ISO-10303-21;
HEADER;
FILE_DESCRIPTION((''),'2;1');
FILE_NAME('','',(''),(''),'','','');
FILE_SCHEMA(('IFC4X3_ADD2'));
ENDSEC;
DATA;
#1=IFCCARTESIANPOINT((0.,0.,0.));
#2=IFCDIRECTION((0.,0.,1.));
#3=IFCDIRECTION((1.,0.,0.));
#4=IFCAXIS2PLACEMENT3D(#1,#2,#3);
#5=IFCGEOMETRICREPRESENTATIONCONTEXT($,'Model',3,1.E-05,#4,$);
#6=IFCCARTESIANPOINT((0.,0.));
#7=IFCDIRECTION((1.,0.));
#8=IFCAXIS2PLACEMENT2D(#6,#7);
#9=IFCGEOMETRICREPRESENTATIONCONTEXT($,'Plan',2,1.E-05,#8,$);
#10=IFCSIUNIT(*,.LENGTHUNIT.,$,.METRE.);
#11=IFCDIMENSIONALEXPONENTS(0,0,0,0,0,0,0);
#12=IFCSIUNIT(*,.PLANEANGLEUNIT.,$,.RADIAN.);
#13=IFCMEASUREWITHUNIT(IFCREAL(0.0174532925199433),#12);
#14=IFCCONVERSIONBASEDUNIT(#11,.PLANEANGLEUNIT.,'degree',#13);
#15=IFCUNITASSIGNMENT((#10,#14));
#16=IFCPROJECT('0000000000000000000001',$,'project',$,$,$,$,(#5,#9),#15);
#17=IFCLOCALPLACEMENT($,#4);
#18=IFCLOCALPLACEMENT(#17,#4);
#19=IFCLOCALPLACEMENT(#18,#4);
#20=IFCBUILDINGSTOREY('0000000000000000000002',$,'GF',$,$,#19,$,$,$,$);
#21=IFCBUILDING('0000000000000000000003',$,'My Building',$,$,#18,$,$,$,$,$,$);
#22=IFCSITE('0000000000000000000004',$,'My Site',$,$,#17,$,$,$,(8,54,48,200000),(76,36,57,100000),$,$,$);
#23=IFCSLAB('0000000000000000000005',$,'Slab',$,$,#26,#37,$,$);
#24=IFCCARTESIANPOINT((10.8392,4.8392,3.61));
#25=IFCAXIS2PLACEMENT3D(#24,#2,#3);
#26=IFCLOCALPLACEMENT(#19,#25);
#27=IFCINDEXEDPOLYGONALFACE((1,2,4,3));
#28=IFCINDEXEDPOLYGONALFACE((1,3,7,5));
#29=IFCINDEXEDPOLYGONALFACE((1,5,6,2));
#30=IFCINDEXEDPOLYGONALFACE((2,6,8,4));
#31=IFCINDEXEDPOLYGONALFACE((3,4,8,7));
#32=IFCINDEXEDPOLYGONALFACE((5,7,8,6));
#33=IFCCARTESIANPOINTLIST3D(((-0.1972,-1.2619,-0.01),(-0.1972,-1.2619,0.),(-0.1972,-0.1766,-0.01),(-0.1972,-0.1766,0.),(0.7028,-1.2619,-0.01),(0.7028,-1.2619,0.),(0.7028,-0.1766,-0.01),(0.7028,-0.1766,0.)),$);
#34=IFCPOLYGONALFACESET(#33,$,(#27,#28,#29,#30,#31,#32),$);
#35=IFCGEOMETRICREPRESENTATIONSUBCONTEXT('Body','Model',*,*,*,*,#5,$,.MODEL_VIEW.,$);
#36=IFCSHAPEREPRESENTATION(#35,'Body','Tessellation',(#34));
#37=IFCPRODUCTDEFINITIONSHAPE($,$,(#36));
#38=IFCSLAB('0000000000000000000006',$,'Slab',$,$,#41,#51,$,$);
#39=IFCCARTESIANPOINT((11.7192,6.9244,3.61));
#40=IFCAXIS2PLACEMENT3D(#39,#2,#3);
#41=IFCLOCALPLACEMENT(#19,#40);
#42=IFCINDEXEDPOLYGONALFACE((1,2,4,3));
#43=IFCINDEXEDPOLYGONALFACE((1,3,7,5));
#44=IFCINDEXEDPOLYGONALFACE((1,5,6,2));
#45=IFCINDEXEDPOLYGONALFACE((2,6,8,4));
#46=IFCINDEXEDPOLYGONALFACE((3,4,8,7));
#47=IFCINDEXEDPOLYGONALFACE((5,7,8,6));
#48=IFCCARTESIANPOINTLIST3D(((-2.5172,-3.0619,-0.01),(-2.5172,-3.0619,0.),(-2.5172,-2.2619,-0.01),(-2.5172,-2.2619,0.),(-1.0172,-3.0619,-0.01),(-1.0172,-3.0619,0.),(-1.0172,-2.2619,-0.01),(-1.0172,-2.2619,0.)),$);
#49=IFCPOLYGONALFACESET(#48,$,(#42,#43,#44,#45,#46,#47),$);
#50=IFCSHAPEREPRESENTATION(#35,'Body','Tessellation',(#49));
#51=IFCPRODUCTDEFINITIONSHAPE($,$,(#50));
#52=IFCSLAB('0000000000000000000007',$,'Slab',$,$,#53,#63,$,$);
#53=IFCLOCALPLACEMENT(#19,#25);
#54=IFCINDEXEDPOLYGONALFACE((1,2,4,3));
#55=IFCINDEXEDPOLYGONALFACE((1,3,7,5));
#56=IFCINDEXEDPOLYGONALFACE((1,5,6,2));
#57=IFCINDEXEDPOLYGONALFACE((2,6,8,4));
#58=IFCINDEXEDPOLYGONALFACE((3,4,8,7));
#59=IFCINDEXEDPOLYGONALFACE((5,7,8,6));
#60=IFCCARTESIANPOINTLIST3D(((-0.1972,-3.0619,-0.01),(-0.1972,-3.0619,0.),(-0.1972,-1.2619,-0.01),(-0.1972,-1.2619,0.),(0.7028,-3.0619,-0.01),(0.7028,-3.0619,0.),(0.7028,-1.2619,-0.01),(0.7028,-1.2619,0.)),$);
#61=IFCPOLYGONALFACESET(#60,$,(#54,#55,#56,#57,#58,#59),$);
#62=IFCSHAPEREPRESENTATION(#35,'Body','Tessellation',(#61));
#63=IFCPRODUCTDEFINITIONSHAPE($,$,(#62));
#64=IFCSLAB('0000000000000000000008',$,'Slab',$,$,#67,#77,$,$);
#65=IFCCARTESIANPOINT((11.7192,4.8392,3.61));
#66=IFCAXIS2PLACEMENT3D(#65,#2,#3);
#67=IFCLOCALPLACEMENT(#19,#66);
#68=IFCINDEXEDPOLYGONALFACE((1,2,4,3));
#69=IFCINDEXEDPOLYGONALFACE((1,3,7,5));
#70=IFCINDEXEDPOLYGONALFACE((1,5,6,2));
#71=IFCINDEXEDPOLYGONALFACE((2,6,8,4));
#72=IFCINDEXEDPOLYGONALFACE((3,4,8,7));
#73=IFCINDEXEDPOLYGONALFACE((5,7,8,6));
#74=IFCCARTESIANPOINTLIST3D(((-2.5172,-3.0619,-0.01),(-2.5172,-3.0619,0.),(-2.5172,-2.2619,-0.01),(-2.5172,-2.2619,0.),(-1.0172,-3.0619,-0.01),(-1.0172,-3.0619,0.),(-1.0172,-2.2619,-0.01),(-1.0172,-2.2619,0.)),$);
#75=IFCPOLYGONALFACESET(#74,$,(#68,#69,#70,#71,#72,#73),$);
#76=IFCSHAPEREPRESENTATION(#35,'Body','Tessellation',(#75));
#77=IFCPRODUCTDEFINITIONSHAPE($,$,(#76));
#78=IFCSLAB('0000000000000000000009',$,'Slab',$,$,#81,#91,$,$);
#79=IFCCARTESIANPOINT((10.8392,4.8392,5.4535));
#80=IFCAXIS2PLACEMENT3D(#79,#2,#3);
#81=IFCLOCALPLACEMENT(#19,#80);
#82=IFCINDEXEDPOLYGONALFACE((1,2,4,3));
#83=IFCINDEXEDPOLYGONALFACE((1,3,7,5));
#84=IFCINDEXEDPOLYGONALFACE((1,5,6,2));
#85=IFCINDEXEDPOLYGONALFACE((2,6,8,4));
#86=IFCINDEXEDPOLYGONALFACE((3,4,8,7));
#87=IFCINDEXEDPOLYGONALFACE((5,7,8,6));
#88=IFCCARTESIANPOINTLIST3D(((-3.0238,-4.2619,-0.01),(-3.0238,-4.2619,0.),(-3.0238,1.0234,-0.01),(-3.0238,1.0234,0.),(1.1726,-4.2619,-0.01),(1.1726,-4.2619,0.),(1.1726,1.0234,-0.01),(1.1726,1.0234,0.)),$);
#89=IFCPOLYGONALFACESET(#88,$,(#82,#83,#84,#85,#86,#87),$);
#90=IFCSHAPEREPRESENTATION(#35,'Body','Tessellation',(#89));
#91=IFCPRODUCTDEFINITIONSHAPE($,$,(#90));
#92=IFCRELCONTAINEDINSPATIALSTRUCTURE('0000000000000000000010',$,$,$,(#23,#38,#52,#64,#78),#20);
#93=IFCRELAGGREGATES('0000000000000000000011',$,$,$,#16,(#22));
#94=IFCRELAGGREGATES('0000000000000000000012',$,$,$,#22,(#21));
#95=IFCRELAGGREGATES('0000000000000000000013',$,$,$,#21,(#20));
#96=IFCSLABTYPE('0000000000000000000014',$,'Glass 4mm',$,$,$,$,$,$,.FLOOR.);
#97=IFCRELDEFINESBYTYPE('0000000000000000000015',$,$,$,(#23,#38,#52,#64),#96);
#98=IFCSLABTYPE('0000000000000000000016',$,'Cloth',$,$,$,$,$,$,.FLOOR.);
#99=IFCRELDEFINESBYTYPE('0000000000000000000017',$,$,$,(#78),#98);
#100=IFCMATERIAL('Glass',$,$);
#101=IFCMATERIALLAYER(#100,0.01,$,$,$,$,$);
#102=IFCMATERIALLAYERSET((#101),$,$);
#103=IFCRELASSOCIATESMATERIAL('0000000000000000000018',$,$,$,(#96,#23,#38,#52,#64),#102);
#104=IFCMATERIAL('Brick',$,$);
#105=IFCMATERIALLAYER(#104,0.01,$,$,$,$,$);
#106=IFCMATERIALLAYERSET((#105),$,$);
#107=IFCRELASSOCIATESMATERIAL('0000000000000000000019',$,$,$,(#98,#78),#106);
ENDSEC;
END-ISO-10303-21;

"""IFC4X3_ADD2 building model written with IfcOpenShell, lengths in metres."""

from ifc_helpers import new_model, entity, si_unit, converted_unit, frame, origin_with_axes, origin_2d_with_axis, place, context, subcontext, project, spatial, indexed_curve, outline, extrude, material, layer, layer_set, layer_usage, type_object, element, save


model = new_model("IFC4X3_ADD2")

# Units and contexts
model_context = context("Model", 3, precision=1e-05, world=origin_with_axes())
plan_context = context("Plan", 2, precision=1e-05, world=origin_2d_with_axis())
body_context = subcontext(model_context, "Body", "Model", "MODEL_VIEW")
ifc_project = project(units=[si_unit("LENGTHUNIT", "METRE"), converted_unit("PLANEANGLEUNIT", "degree", entity("IfcReal", 0.0174532925199433), si_unit("PLANEANGLEUNIT", "RADIAN"), dimensions=[0, 0, 0, 0, 0, 0, 0])], contexts=[model_context, plan_context])

# Site, building, storey
site_placement = place(None, origin_with_axes())
site = spatial("IfcSite", under=ifc_project, at=site_placement, Name="My Site", RefLatitude=(8, 54, 48, 200000), RefLongitude=(76, 36, 57, 100000))
building_placement = place(site_placement, origin_with_axes())
building = spatial("IfcBuilding", under=site, at=building_placement, Name="My Building")
storey_placement = place(building_placement, origin_with_axes())
storey = spatial("IfcBuildingStorey", under=building, at=storey_placement, Name="GF")

# Slabs
ifc_material_1 = material(Name="Glass")
ifc_layer_1 = layer(ifc_material_1, 0.01)
ifc_layer_set_1 = layer_set([ifc_layer_1])
ifc_layer_usage_1 = layer_usage(ifc_layer_set_1, "AXIS3", "POSITIVE", -0.01)
slab_type_1 = type_object("IfcSlabType", Name="Glass 4mm", PredefinedType="FLOOR", material=ifc_layer_set_1)
slab_1_placement = place(storey_placement, frame((10.8392, 4.8392, 3.61), z_axis=(0.0, 0.0, 1.0), x_axis=(1.0, 0.0, 0.0)))
element("IfcSlab", 1, at=slab_1_placement, inside=storey, type_object=slab_type_1, material=ifc_layer_usage_1, Name="Slab", context=body_context, shape_type="SweptSolid", body=[
    extrude(outline(indexed_curve([(-0.1972, -0.1766), (0.7028, -0.1766), (0.7028, -1.2619), (-0.1972, -1.2619), (-0.1972, -0.1766)])), frame((0.0, 0.0, -0.01), z_axis=(0.0, 0.0, 1.0), x_axis=(1.0, 0.0, 0.0)), (0.0, 0.0, 1.0), 0.01),
])
ifc_layer_usage_2 = layer_usage(ifc_layer_set_1, "AXIS3", "POSITIVE", -0.01)
slab_2_placement = place(storey_placement, frame((11.7192, 6.9244, 3.61), z_axis=(0.0, 0.0, 1.0), x_axis=(1.0, 0.0, 0.0)))
element("IfcSlab", 2, at=slab_2_placement, inside=storey, type_object=slab_type_1, material=ifc_layer_usage_2, Name="Slab", context=body_context, shape_type="SweptSolid", body=[
    extrude(outline(indexed_curve([(-1.0172, -2.2619), (-1.0172, -3.0619), (-2.5172, -3.0619), (-2.5172, -2.2619), (-1.0172, -2.2619)])), frame((0.0, 0.0, -0.01), z_axis=(0.0, 0.0, 1.0), x_axis=(1.0, 0.0, 0.0)), (0.0, 0.0, 1.0), 0.01),
])
ifc_layer_usage_3 = layer_usage(ifc_layer_set_1, "AXIS3", "POSITIVE", -0.01)
slab_3_placement = place(storey_placement, frame((10.8392, 4.8392, 3.61), z_axis=(0.0, 0.0, 1.0), x_axis=(1.0, 0.0, 0.0)))
element("IfcSlab", 3, at=slab_3_placement, inside=storey, type_object=slab_type_1, material=ifc_layer_usage_3, Name="Slab", context=body_context, shape_type="SweptSolid", body=[
    extrude(outline(indexed_curve([(-0.1972, -3.0619), (0.7028, -3.0619), (0.7028, -1.2619), (-0.1972, -1.2619), (-0.1972, -3.0619)])), frame((0.0, 0.0, -0.01), z_axis=(0.0, 0.0, 1.0), x_axis=(1.0, 0.0, 0.0)), (0.0, 0.0, 1.0), 0.01),
])
ifc_layer_usage_4 = layer_usage(ifc_layer_set_1, "AXIS3", "POSITIVE", -0.01)
slab_4_placement = place(storey_placement, frame((11.7192, 4.8392, 3.61), z_axis=(0.0, 0.0, 1.0), x_axis=(1.0, 0.0, 0.0)))
element("IfcSlab", 4, at=slab_4_placement, inside=storey, type_object=slab_type_1, material=ifc_layer_usage_4, Name="Slab", context=body_context, shape_type="SweptSolid", body=[
    extrude(outline(indexed_curve([(-1.0172, -2.2619), (-1.0172, -3.0619), (-2.5172, -3.0619), (-2.5172, -2.2619), (-1.0172, -2.2619)])), frame((0.0, 0.0, -0.01), z_axis=(0.0, 0.0, 1.0), x_axis=(1.0, 0.0, 0.0)), (0.0, 0.0, 1.0), 0.01),
])
ifc_material_2 = material(Name="Brick")
ifc_layer_2 = layer(ifc_material_2, 0.01)
ifc_layer_set_2 = layer_set([ifc_layer_2])
ifc_layer_usage_5 = layer_usage(ifc_layer_set_2, "AXIS3", "POSITIVE", -0.01)
slab_type_2 = type_object("IfcSlabType", Name="Cloth", PredefinedType="FLOOR", material=ifc_layer_set_2)
slab_5_placement = place(storey_placement, frame((10.8392, 4.8392, 5.4535), z_axis=(0.0, 0.0, 1.0), x_axis=(1.0, 0.0, 0.0)))
element("IfcSlab", 5, at=slab_5_placement, inside=storey, type_object=slab_type_2, material=ifc_layer_usage_5, Name="Slab", context=body_context, shape_type="SweptSolid", body=[
    extrude(outline(indexed_curve([(-3.0238, 1.0234), (1.1726, 1.0234), (1.1726, -4.2619), (-3.0238, -4.2619), (-3.0238, 1.0234)])), frame((0.0, 0.0, -0.01), z_axis=(0.0, 0.0, 1.0), x_axis=(1.0, 0.0, 0.0)), (0.0, 0.0, 1.0), 0.01),
])

save(model, "model.ifc")
